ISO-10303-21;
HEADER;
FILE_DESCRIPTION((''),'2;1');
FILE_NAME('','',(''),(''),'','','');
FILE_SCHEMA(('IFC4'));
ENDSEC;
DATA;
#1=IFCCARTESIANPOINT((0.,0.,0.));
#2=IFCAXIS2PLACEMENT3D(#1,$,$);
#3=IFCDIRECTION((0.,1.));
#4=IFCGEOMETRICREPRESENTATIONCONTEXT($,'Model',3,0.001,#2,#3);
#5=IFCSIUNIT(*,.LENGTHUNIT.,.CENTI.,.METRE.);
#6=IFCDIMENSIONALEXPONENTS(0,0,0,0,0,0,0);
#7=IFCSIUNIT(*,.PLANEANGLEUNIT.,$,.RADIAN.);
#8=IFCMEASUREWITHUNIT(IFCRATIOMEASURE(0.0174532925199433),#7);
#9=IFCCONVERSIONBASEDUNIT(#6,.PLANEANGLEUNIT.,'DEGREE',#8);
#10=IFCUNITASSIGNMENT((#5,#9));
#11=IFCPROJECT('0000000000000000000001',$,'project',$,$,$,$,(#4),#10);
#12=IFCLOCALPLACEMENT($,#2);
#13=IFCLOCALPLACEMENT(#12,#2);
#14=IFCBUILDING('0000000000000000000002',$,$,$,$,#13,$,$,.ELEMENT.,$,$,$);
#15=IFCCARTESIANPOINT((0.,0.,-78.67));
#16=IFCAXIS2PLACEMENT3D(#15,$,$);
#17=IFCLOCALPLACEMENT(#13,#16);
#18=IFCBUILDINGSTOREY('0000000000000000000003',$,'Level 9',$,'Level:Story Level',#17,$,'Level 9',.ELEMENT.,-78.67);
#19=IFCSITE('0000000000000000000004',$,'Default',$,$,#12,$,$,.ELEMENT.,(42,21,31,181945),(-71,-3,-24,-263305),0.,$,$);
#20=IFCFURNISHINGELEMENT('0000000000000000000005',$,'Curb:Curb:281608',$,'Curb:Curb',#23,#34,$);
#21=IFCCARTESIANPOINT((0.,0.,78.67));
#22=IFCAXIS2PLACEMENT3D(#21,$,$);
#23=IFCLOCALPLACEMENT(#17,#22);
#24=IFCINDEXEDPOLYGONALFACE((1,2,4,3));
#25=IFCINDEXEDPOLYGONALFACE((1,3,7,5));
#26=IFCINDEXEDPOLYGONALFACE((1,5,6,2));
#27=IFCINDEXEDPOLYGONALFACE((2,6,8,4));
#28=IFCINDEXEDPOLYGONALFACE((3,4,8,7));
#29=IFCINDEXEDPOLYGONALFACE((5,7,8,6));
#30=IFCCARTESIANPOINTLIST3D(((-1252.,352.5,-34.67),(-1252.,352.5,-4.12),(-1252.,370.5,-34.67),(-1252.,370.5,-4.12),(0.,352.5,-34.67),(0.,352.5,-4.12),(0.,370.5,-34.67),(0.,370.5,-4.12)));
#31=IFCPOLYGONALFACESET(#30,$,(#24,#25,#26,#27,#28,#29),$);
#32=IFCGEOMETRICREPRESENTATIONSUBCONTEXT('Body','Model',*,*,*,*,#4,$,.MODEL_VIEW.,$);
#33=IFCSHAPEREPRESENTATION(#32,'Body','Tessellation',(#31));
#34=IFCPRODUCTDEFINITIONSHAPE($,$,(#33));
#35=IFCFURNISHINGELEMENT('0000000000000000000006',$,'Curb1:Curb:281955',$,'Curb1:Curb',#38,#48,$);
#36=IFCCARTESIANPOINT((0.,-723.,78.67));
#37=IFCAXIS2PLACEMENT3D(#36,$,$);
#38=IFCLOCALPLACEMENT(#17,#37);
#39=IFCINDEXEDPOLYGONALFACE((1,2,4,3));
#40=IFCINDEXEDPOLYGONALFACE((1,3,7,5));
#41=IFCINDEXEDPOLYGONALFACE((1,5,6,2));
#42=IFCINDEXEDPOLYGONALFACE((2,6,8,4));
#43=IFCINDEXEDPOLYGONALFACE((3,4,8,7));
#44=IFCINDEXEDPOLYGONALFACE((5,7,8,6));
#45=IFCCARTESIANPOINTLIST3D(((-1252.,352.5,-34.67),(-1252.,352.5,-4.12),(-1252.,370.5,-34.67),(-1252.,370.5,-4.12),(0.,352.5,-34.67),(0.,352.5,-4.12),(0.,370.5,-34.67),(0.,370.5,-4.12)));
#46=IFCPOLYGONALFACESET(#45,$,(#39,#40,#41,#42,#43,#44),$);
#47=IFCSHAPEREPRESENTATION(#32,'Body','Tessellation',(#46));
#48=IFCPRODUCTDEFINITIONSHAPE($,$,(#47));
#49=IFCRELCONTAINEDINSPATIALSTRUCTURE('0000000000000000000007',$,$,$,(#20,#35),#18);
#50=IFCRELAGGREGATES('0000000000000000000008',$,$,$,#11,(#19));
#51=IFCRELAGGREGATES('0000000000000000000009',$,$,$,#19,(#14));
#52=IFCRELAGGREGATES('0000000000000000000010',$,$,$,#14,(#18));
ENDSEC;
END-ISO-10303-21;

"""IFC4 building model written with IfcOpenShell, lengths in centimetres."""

from ifc_helpers import new_model, entity, si_unit, converted_unit, direction, frame, frame_2d, origin, place, context, subcontext, project, spatial, rectangle, extrude, source, transform, mapped, element, save


model = new_model("IFC4")

# Units and contexts
model_context = context("Model", 3, precision=0.001, world=origin(), true_north=direction((0.0, 1.0)))
body_context = subcontext(model_context, "Body", "Model", "MODEL_VIEW")
ifc_project = project(units=[si_unit("LENGTHUNIT", "METRE", prefix="CENTI"), converted_unit("PLANEANGLEUNIT", "DEGREE", entity("IfcRatioMeasure", 0.0174532925199433), si_unit("PLANEANGLEUNIT", "RADIAN"), dimensions=[0, 0, 0, 0, 0, 0, 0])], contexts=[model_context])

# Site, building, storey
site_placement = place(None, origin())
site = spatial("IfcSite", under=ifc_project, at=site_placement, Name="Default", CompositionType="ELEMENT", RefLatitude=(42, 21, 31, 181945), RefLongitude=(-71, -3, -24, -263305), RefElevation=0.0)
building_placement = place(site_placement, origin())
building = spatial("IfcBuilding", under=site, at=building_placement, CompositionType="ELEMENT")
storey_placement = place(building_placement, frame((0.0, 0.0, -78.67)))
storey = spatial("IfcBuildingStorey", under=building, at=storey_placement, Name="Level 9", ObjectType="Level:Story Level", LongName="Level 9", CompositionType="ELEMENT", Elevation=-78.67)

# Furnishing elements
shared_shape_1 = source(origin(), body_context, "Body", "SweptSolid", [
    extrude(rectangle(XDim=1252.0, YDim=18.0, at=frame_2d((0.0, 0.0), x_axis=(1.0, 0.0))), frame((-626.0, 361.5, -34.67)), (0.0, 0.0, 1.0), 30.55),
])
furnishing_1_placement = place(storey_placement, frame((0.0, 0.0, 78.67)))
element("IfcFurnishingElement", 1, at=furnishing_1_placement, inside=storey, Name="Curb:Curb:281608", ObjectType="Curb:Curb", context=body_context, shape_type="MappedRepresentation", body=[
    mapped(shared_shape_1, transform((0.0, 0.0, 0.0), scale=1.0)),
])
shared_shape_2 = source(origin(), body_context, "Body", "SweptSolid", [
    extrude(rectangle(XDim=1252.0, YDim=18.0, at=frame_2d((0.0, 0.0), x_axis=(1.0, 0.0))), frame((-626.0, 361.5, -34.67)), (0.0, 0.0, 1.0), 30.55),
])
furnishing_2_placement = place(storey_placement, frame((0.0, -723.0, 78.67)))
element("IfcFurnishingElement", 2, at=furnishing_2_placement, inside=storey, Name="Curb1:Curb:281955", ObjectType="Curb1:Curb", context=body_context, shape_type="MappedRepresentation", body=[
    mapped(shared_shape_2, transform((0.0, 0.0, 0.0), scale=1.0)),
])

save(model, "model.ifc")
